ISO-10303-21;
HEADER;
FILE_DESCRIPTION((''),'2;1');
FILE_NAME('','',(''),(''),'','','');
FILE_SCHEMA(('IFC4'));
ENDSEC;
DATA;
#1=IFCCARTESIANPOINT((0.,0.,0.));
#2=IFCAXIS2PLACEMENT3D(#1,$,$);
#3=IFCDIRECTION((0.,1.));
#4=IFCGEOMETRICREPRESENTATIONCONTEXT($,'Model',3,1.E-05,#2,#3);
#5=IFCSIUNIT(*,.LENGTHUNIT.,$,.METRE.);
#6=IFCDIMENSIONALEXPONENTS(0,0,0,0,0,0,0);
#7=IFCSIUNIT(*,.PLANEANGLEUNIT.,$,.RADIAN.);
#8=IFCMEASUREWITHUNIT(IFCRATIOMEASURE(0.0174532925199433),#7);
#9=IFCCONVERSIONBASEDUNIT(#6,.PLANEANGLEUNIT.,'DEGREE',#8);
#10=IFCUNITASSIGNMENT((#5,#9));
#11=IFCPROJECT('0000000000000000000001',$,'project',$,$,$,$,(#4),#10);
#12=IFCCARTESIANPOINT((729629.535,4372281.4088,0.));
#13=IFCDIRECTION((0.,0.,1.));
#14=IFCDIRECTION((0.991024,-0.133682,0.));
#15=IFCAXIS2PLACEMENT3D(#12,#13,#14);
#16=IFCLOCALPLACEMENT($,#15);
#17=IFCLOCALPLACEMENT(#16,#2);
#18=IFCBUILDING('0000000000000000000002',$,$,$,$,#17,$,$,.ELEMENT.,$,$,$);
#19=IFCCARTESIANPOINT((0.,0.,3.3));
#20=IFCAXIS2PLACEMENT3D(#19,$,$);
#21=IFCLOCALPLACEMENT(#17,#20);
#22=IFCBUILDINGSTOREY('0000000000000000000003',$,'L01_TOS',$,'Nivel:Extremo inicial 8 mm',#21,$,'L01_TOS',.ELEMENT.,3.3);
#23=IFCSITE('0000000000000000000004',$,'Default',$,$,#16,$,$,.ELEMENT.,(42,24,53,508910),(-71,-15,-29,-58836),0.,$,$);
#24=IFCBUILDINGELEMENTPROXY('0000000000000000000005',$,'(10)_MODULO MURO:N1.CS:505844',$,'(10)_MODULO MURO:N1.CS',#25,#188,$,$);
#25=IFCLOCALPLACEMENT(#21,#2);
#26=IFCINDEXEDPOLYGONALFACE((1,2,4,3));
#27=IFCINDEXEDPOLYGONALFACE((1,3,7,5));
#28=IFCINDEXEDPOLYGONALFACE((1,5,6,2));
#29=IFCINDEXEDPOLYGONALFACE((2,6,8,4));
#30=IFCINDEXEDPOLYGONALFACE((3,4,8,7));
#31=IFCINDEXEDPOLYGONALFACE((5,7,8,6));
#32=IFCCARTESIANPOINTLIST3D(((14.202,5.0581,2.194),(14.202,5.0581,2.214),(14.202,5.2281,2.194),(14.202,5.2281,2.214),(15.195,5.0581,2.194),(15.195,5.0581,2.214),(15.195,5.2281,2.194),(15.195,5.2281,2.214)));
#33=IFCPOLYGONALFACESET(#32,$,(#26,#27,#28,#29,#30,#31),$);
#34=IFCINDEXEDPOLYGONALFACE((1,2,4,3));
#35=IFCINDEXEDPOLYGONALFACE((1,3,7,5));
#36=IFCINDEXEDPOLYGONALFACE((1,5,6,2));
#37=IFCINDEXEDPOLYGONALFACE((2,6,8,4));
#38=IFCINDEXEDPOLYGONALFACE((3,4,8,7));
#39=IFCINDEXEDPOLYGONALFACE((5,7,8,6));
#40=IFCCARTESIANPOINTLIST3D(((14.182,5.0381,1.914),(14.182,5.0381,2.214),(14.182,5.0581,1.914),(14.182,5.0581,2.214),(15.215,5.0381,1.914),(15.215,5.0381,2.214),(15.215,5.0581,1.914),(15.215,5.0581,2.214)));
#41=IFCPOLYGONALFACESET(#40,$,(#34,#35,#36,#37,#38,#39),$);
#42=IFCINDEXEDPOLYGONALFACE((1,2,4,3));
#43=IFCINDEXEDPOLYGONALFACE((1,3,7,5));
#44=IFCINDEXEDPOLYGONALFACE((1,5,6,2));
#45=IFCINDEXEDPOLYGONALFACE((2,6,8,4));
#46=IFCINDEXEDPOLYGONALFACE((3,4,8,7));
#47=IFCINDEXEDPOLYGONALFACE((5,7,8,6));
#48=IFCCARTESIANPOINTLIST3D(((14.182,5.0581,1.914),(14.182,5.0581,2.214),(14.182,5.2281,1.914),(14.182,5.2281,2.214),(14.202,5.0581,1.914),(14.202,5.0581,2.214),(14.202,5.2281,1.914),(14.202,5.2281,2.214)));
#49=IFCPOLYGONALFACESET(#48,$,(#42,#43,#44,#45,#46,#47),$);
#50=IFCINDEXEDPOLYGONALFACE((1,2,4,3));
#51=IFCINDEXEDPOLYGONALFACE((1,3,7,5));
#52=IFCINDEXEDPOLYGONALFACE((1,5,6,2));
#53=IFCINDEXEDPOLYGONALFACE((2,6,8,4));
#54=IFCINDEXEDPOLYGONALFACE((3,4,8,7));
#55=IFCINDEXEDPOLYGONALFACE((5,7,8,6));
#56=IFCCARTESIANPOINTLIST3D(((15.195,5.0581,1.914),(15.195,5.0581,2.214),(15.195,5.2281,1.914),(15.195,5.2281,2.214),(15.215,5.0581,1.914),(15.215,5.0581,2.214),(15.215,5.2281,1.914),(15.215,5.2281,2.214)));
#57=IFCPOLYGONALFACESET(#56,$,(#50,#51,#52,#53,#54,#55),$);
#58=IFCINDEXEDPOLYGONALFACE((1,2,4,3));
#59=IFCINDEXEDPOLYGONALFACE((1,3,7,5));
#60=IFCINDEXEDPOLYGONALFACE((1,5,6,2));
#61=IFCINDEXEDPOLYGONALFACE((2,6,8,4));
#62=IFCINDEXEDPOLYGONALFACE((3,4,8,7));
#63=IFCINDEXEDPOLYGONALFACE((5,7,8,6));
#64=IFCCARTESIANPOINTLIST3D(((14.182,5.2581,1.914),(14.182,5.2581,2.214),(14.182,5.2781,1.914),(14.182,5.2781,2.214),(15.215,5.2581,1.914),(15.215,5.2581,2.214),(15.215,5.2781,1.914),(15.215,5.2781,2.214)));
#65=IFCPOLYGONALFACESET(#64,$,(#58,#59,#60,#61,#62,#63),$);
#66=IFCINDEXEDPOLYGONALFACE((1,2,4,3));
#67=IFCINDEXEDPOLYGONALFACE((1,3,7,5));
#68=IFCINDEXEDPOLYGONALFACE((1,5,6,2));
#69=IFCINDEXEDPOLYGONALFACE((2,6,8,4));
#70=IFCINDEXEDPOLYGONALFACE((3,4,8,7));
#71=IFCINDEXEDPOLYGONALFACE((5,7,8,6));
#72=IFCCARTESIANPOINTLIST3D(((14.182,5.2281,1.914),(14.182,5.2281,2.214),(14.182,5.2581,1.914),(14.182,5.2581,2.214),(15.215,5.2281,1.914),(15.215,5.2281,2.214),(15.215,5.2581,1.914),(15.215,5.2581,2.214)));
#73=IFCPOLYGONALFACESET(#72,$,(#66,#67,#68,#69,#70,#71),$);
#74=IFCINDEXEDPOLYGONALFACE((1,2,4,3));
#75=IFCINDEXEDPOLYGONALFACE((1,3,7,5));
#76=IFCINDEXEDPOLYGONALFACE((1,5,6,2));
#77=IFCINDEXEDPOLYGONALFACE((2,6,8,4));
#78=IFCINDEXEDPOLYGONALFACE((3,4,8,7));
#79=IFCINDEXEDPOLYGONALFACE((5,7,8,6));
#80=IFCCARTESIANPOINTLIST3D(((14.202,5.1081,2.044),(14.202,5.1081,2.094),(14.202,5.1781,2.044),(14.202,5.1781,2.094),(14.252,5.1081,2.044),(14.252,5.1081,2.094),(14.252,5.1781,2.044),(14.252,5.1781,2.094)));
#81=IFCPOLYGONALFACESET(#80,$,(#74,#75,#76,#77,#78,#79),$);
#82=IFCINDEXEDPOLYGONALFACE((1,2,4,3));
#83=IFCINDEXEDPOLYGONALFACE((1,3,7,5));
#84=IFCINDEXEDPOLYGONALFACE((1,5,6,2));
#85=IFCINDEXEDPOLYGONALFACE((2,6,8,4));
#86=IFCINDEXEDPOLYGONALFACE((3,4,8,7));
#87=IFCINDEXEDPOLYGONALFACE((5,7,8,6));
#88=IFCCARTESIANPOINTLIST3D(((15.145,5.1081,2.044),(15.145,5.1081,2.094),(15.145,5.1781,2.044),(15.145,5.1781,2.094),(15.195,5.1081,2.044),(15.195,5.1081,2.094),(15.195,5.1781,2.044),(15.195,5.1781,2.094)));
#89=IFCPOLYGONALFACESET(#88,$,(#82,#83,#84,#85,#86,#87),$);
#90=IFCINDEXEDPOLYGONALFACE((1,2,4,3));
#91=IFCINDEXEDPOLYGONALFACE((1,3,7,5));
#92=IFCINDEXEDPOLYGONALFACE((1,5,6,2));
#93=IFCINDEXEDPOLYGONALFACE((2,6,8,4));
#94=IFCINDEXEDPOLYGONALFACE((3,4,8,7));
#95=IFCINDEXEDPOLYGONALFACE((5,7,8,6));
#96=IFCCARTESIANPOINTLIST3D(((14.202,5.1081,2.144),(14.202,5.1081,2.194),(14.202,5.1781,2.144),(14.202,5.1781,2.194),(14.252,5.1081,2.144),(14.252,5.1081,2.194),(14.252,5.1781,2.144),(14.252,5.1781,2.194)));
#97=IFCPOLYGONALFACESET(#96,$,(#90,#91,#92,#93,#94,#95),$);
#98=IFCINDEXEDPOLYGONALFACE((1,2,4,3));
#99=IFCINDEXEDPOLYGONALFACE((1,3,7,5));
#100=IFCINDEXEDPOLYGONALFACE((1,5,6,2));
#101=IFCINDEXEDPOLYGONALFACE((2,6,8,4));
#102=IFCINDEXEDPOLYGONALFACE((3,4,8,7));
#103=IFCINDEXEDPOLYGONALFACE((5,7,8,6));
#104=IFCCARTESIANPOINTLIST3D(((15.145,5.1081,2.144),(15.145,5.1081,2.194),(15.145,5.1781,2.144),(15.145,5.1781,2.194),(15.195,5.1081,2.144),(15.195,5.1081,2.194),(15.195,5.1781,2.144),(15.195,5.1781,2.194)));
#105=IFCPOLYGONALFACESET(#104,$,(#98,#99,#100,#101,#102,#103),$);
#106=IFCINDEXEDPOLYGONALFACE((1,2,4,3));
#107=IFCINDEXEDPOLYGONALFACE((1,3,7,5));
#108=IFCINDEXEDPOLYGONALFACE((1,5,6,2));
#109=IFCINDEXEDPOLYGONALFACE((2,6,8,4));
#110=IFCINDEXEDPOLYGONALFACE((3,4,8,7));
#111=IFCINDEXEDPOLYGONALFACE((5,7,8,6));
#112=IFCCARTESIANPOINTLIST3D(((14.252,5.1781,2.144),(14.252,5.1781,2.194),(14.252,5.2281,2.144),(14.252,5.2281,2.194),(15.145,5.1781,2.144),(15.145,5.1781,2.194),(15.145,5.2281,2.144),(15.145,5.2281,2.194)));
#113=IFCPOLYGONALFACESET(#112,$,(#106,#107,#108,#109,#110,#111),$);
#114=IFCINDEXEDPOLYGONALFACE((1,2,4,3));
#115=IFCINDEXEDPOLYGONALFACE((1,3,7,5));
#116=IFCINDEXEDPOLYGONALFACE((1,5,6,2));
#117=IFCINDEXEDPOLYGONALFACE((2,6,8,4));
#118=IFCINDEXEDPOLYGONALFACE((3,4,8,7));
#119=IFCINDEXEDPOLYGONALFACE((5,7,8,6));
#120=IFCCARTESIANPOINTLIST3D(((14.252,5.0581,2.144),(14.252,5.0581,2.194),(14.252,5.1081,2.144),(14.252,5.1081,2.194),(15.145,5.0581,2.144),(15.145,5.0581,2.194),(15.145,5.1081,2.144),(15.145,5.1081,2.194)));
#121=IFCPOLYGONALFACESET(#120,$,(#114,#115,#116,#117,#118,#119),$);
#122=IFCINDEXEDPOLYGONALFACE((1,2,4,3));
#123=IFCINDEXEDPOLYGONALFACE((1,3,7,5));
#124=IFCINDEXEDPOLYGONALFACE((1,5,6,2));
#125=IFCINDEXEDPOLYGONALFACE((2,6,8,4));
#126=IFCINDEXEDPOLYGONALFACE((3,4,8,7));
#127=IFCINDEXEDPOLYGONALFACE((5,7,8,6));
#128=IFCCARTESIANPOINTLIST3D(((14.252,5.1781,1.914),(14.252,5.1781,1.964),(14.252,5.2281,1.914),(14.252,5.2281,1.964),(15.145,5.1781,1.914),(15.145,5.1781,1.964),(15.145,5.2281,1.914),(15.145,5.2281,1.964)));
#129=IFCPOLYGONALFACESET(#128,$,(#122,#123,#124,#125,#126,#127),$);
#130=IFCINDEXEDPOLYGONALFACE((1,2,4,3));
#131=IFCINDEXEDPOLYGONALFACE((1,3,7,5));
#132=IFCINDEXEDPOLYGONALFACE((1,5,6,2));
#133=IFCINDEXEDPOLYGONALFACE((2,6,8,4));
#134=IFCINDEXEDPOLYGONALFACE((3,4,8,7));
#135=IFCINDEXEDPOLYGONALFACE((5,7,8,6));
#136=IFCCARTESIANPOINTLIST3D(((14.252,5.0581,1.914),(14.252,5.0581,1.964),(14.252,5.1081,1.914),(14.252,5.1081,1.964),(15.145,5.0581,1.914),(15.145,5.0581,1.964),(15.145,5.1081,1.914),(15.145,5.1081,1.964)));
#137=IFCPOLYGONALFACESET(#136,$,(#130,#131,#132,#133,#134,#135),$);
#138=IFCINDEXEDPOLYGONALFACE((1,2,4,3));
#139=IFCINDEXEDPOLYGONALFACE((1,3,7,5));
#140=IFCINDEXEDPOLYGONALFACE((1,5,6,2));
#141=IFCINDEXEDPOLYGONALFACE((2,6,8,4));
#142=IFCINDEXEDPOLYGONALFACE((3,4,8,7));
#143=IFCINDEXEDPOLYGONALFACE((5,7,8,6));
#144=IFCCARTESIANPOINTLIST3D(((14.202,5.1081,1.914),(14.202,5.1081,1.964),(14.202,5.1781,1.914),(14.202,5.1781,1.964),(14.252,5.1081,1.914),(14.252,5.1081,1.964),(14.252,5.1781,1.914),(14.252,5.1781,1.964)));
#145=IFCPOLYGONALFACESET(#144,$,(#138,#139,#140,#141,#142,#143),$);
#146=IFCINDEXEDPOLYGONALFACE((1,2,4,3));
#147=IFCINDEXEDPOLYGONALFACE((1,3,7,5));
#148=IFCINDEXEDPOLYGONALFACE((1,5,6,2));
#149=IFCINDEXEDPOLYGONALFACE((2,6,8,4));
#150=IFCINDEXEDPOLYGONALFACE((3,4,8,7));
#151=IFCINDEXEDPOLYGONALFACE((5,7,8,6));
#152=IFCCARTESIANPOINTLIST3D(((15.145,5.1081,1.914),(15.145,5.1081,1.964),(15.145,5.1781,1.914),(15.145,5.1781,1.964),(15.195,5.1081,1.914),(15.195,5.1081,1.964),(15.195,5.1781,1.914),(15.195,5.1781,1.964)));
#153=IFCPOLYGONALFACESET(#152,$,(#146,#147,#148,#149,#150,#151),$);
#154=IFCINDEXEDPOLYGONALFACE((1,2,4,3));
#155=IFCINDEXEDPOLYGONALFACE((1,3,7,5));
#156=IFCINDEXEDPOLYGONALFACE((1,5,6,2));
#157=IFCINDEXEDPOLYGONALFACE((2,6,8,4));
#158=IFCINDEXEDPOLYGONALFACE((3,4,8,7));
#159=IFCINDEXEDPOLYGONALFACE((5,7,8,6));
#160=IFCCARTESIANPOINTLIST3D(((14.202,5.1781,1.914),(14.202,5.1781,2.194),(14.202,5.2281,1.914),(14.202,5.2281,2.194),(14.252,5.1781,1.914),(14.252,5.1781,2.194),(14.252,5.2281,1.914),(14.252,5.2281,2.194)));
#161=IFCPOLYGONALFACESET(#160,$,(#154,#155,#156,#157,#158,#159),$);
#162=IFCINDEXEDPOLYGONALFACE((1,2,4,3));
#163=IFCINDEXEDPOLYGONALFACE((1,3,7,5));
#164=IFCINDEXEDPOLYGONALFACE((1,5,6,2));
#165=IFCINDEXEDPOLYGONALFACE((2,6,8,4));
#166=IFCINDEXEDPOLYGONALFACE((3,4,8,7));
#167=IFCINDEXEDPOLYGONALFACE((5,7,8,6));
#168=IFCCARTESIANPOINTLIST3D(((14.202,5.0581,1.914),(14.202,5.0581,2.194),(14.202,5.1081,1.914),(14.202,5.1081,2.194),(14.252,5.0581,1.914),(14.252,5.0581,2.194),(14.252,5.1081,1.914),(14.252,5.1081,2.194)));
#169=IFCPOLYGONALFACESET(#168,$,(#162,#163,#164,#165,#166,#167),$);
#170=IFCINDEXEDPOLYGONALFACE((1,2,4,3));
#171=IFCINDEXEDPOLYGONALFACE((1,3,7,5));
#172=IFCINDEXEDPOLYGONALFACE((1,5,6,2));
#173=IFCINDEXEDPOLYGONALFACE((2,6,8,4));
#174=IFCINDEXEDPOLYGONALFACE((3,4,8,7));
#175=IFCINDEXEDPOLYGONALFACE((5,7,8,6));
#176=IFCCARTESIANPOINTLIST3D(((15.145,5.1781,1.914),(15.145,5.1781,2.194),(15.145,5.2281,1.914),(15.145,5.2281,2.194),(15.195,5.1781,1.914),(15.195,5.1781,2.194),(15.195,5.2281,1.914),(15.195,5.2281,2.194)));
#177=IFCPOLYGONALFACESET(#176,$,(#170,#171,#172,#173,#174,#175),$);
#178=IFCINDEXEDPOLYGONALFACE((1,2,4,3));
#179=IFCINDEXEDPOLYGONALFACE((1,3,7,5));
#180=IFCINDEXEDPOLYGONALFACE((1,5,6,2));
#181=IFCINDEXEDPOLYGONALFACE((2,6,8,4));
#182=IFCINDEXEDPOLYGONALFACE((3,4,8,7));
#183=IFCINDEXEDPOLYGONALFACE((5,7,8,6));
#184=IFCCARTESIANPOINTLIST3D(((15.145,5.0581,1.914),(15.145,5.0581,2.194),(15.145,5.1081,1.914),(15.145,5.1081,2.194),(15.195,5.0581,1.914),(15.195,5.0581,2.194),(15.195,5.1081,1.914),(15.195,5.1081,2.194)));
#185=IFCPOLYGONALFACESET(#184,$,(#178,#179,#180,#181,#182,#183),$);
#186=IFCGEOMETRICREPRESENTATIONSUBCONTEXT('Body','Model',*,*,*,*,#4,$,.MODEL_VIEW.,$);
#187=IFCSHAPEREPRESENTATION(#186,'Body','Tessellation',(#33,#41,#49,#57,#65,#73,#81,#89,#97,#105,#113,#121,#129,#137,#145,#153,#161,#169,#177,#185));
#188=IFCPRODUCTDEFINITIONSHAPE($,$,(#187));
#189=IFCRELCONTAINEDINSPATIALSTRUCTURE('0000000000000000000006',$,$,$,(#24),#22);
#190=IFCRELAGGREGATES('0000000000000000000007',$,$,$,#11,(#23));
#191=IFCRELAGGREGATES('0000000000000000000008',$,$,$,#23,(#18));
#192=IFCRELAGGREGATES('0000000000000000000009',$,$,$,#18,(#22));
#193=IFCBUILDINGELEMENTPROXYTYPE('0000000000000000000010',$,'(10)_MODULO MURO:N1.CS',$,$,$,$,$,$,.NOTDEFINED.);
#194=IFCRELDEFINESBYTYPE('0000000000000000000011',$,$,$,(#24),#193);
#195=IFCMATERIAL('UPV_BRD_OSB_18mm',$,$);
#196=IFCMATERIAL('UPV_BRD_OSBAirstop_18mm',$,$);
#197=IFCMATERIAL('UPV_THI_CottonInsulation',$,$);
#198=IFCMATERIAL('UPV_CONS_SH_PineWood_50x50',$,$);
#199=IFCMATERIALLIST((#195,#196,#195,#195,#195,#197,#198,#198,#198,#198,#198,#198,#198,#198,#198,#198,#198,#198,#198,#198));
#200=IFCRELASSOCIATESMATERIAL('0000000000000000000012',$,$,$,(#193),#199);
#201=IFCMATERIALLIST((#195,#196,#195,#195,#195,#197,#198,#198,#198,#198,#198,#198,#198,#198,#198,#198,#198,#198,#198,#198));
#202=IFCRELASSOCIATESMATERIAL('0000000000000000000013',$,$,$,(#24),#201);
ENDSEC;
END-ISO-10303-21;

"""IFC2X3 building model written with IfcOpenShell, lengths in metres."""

from ifc_helpers import new_model, entity, si_unit, converted_unit, direction, frame, frame_2d, origin, origin_2d_with_axis, place, context, subcontext, project, spatial, rectangle, extrude, source, transform, mapped, material, material_list, type_object, type_shapes, element, save


model = new_model("IFC2X3")

# Units and contexts
model_context = context("Model", 3, precision=1e-05, world=origin(), true_north=direction((0.0, 1.0)))
body_context = subcontext(model_context, "Body", "Model", "MODEL_VIEW")
ifc_project = project(units=[si_unit("LENGTHUNIT", "METRE"), converted_unit("PLANEANGLEUNIT", "DEGREE", entity("IfcRatioMeasure", 0.0174532925199433), si_unit("PLANEANGLEUNIT", "RADIAN"), dimensions=[0, 0, 0, 0, 0, 0, 0])], contexts=[model_context])

# Site, building, storey
site_placement = place(None, frame((729629.535, 4372281.4088, 0.0), z_axis=(0.0, 0.0, 1.0), x_axis=(0.991024, -0.133682, 0.0)))
site = spatial("IfcSite", under=ifc_project, at=site_placement, Name="Default", CompositionType="ELEMENT", RefLatitude=(42, 24, 53, 508910), RefLongitude=(-71, -15, -29, -58836), RefElevation=0.0)
building_placement = place(site_placement, origin())
building = spatial("IfcBuilding", under=site, at=building_placement, CompositionType="ELEMENT")
storey_placement = place(building_placement, frame((0.0, 0.0, 3.3)))
storey = spatial("IfcBuildingStorey", under=building, at=storey_placement, Name="L01_TOS", ObjectType="Nivel:Extremo inicial 8 mm", LongName="L01_TOS", CompositionType="ELEMENT", Elevation=3.3)

# Building element proxy
ifc_material_1 = material(Name="UPV_BRD_OSB_18mm")
ifc_material_2 = material(Name="UPV_CONS_SH_PineWood_50x50")
ifc_material_3 = material(Name="UPV_BRD_OSBAirstop_18mm")
ifc_material_4 = material(Name="UPV_THI_CottonInsulation")
ifc_material_list_1 = material_list([ifc_material_1, ifc_material_3, ifc_material_1, ifc_material_1, ifc_material_1, ifc_material_4, ifc_material_2, ifc_material_2, ifc_material_2, ifc_material_2, ifc_material_2, ifc_material_2, ifc_material_2, ifc_material_2, ifc_material_2, ifc_material_2, ifc_material_2, ifc_material_2, ifc_material_2, ifc_material_2])
ifc_material_list_2 = material_list([ifc_material_1, ifc_material_3, ifc_material_1, ifc_material_1, ifc_material_1, ifc_material_4, ifc_material_2, ifc_material_2, ifc_material_2, ifc_material_2, ifc_material_2, ifc_material_2, ifc_material_2, ifc_material_2, ifc_material_2, ifc_material_2, ifc_material_2, ifc_material_2, ifc_material_2, ifc_material_2])
building_element_proxy_type_1 = type_object("IfcBuildingElementProxyType", Name="(10)_MODULO MURO:N1.CS", PredefinedType="NOTDEFINED", material=ifc_material_list_2)
shared_shape_1 = source(origin(), body_context, "Body", "SweptSolid", [
    extrude(rectangle(XDim=0.993, YDim=0.17, at=frame_2d((0.0, 0.0), x_axis=(1.0, 0.0))), frame((0.0, 0.0, 0.28), z_axis=(0.0, 0.0, 1.0), x_axis=(-1.0, 0.0, 0.0)), (0.0, 0.0, 1.0), 0.02),
    extrude(rectangle(XDim=1.033, YDim=0.02, at=origin_2d_with_axis()), frame((0.0, -0.095, 0.0)), (0.0, 0.0, 1.0), 0.3),
    extrude(rectangle(XDim=0.17, YDim=0.02, at=frame_2d((0.0, 0.0), x_axis=(1.0, 0.0))), frame((-0.5065, 0.0, 0.0), z_axis=(0.0, 0.0, 1.0), x_axis=(0.0, -1.0, 0.0)), (0.0, 0.0, 1.0), 0.3),
    extrude(rectangle(XDim=0.17, YDim=0.02, at=frame_2d((0.0, 0.0), x_axis=(1.0, 0.0))), frame((0.5065, 0.0, 0.0), z_axis=(0.0, 0.0, 1.0), x_axis=(0.0, -1.0, 0.0)), (0.0, 0.0, 1.0), 0.3),
    extrude(rectangle(XDim=1.033, YDim=0.02, at=origin_2d_with_axis()), frame((0.0, 0.125, 0.0), z_axis=(0.0, 0.0, 1.0), x_axis=(-1.0, 0.0, 0.0)), (0.0, 0.0, 1.0), 0.3),
    extrude(rectangle(XDim=1.033, YDim=0.03, at=frame_2d((0.0, 0.0), x_axis=(1.0, 0.0))), frame((0.0, 0.1, 0.0), z_axis=(0.0, 0.0, 1.0), x_axis=(-1.0, 0.0, 0.0)), (0.0, 0.0, 1.0), 0.3),
    extrude(rectangle(XDim=0.07, YDim=0.05, at=frame_2d((0.0, 0.0), x_axis=(1.0, 0.0))), frame((-0.4715, 0.0, 0.13), z_axis=(0.0, 0.0, 1.0), x_axis=(0.0, 1.0, 0.0)), (0.0, 0.0, 1.0), 0.05),
    extrude(rectangle(XDim=0.07, YDim=0.05, at=origin_2d_with_axis()), frame((0.4715, 0.0, 0.13), z_axis=(0.0, 0.0, 1.0), x_axis=(0.0, 1.0, 0.0)), (0.0, 0.0, 1.0), 0.05),
    extrude(rectangle(XDim=0.07, YDim=0.05, at=frame_2d((0.0, 0.0), x_axis=(1.0, 0.0))), frame((-0.4715, 0.0, 0.23), z_axis=(0.0, 0.0, 1.0), x_axis=(0.0, -1.0, 0.0)), (0.0, 0.0, 1.0), 0.05),
    extrude(rectangle(XDim=0.07, YDim=0.05, at=frame_2d((0.0, 0.0), x_axis=(1.0, 0.0))), frame((0.4715, 0.0, 0.23), z_axis=(0.0, 0.0, 1.0), x_axis=(0.0, -1.0, 0.0)), (0.0, 0.0, 1.0), 0.05),
    extrude(rectangle(XDim=0.893, YDim=0.05, at=origin_2d_with_axis()), frame((0.0, 0.06, 0.23), z_axis=(0.0, 0.0, 1.0), x_axis=(-1.0, 0.0, 0.0)), (0.0, 0.0, 1.0), 0.05),
    extrude(rectangle(XDim=0.05, YDim=0.893, at=frame_2d((0.0, 0.0), x_axis=(1.0, 0.0))), frame((0.0, -0.06, 0.23), z_axis=(0.0, 0.0, 1.0), x_axis=(0.0, -1.0, 0.0)), (0.0, 0.0, 1.0), 0.05),
    extrude(rectangle(XDim=0.05, YDim=0.893, at=origin_2d_with_axis()), frame((0.0, 0.06, 0.0), z_axis=(0.0, 0.0, 1.0), x_axis=(0.0, -1.0, 0.0)), (0.0, 0.0, 1.0), 0.05),
    extrude(rectangle(XDim=0.05, YDim=0.893, at=frame_2d((0.0, 0.0), x_axis=(1.0, 0.0))), frame((0.0, -0.06, 0.0), z_axis=(0.0, 0.0, 1.0), x_axis=(0.0, -1.0, 0.0)), (0.0, 0.0, 1.0), 0.05),
    extrude(rectangle(XDim=0.07, YDim=0.05, at=frame_2d((0.0, 0.0), x_axis=(1.0, 0.0))), frame((-0.4715, 0.0, 0.0), z_axis=(0.0, 0.0, 1.0), x_axis=(0.0, -1.0, 0.0)), (0.0, 0.0, 1.0), 0.05),
    extrude(rectangle(XDim=0.05, YDim=0.07, at=frame_2d((0.0, 0.0), x_axis=(1.0, 0.0))), frame((0.4715, 0.0, 0.0), z_axis=(0.0, 0.0, 1.0), x_axis=(-1.0, 0.0, 0.0)), (0.0, 0.0, 1.0), 0.05),
    extrude(rectangle(XDim=0.05, YDim=0.05, at=frame_2d((0.0, 0.0), x_axis=(1.0, 0.0))), frame((-0.4715, 0.06, 0.0), z_axis=(0.0, 0.0, 1.0), x_axis=(0.0, -1.0, 0.0)), (0.0, 0.0, 1.0), 0.28),
    extrude(rectangle(XDim=0.05, YDim=0.05, at=frame_2d((0.0, 0.0), x_axis=(1.0, 0.0))), frame((-0.4715, -0.06, 0.0), z_axis=(0.0, 0.0, 1.0), x_axis=(0.0, -1.0, 0.0)), (0.0, 0.0, 1.0), 0.28),
    extrude(rectangle(XDim=0.05, YDim=0.05, at=frame_2d((0.0, 0.0), x_axis=(1.0, 0.0))), frame((0.4715, 0.06, 0.0), z_axis=(0.0, 0.0, 1.0), x_axis=(0.0, -1.0, 0.0)), (0.0, 0.0, 1.0), 0.28),
    extrude(rectangle(XDim=0.05, YDim=0.05, at=frame_2d((0.0, 0.0), x_axis=(1.0, 0.0))), frame((0.4715, -0.06, 0.0), z_axis=(0.0, 0.0, 1.0), x_axis=(0.0, -1.0, 0.0)), (0.0, 0.0, 1.0), 0.28),
])
type_shapes(building_element_proxy_type_1, [shared_shape_1])
proxy_1_placement = place(storey_placement, frame((14.6985, 5.1431, 1.914)))
element("IfcBuildingElementProxy", 1, at=proxy_1_placement, inside=storey, type_object=building_element_proxy_type_1, material=ifc_material_list_1, Name="(10)_MODULO MURO:N1.CS:505844", ObjectType="(10)_MODULO MURO:N1.CS", context=body_context, shape_type="MappedRepresentation", body=[
    mapped(shared_shape_1, transform((0.0, 0.0, 0.0), scale=1.0)),
])

save(model, "model.ifc")
